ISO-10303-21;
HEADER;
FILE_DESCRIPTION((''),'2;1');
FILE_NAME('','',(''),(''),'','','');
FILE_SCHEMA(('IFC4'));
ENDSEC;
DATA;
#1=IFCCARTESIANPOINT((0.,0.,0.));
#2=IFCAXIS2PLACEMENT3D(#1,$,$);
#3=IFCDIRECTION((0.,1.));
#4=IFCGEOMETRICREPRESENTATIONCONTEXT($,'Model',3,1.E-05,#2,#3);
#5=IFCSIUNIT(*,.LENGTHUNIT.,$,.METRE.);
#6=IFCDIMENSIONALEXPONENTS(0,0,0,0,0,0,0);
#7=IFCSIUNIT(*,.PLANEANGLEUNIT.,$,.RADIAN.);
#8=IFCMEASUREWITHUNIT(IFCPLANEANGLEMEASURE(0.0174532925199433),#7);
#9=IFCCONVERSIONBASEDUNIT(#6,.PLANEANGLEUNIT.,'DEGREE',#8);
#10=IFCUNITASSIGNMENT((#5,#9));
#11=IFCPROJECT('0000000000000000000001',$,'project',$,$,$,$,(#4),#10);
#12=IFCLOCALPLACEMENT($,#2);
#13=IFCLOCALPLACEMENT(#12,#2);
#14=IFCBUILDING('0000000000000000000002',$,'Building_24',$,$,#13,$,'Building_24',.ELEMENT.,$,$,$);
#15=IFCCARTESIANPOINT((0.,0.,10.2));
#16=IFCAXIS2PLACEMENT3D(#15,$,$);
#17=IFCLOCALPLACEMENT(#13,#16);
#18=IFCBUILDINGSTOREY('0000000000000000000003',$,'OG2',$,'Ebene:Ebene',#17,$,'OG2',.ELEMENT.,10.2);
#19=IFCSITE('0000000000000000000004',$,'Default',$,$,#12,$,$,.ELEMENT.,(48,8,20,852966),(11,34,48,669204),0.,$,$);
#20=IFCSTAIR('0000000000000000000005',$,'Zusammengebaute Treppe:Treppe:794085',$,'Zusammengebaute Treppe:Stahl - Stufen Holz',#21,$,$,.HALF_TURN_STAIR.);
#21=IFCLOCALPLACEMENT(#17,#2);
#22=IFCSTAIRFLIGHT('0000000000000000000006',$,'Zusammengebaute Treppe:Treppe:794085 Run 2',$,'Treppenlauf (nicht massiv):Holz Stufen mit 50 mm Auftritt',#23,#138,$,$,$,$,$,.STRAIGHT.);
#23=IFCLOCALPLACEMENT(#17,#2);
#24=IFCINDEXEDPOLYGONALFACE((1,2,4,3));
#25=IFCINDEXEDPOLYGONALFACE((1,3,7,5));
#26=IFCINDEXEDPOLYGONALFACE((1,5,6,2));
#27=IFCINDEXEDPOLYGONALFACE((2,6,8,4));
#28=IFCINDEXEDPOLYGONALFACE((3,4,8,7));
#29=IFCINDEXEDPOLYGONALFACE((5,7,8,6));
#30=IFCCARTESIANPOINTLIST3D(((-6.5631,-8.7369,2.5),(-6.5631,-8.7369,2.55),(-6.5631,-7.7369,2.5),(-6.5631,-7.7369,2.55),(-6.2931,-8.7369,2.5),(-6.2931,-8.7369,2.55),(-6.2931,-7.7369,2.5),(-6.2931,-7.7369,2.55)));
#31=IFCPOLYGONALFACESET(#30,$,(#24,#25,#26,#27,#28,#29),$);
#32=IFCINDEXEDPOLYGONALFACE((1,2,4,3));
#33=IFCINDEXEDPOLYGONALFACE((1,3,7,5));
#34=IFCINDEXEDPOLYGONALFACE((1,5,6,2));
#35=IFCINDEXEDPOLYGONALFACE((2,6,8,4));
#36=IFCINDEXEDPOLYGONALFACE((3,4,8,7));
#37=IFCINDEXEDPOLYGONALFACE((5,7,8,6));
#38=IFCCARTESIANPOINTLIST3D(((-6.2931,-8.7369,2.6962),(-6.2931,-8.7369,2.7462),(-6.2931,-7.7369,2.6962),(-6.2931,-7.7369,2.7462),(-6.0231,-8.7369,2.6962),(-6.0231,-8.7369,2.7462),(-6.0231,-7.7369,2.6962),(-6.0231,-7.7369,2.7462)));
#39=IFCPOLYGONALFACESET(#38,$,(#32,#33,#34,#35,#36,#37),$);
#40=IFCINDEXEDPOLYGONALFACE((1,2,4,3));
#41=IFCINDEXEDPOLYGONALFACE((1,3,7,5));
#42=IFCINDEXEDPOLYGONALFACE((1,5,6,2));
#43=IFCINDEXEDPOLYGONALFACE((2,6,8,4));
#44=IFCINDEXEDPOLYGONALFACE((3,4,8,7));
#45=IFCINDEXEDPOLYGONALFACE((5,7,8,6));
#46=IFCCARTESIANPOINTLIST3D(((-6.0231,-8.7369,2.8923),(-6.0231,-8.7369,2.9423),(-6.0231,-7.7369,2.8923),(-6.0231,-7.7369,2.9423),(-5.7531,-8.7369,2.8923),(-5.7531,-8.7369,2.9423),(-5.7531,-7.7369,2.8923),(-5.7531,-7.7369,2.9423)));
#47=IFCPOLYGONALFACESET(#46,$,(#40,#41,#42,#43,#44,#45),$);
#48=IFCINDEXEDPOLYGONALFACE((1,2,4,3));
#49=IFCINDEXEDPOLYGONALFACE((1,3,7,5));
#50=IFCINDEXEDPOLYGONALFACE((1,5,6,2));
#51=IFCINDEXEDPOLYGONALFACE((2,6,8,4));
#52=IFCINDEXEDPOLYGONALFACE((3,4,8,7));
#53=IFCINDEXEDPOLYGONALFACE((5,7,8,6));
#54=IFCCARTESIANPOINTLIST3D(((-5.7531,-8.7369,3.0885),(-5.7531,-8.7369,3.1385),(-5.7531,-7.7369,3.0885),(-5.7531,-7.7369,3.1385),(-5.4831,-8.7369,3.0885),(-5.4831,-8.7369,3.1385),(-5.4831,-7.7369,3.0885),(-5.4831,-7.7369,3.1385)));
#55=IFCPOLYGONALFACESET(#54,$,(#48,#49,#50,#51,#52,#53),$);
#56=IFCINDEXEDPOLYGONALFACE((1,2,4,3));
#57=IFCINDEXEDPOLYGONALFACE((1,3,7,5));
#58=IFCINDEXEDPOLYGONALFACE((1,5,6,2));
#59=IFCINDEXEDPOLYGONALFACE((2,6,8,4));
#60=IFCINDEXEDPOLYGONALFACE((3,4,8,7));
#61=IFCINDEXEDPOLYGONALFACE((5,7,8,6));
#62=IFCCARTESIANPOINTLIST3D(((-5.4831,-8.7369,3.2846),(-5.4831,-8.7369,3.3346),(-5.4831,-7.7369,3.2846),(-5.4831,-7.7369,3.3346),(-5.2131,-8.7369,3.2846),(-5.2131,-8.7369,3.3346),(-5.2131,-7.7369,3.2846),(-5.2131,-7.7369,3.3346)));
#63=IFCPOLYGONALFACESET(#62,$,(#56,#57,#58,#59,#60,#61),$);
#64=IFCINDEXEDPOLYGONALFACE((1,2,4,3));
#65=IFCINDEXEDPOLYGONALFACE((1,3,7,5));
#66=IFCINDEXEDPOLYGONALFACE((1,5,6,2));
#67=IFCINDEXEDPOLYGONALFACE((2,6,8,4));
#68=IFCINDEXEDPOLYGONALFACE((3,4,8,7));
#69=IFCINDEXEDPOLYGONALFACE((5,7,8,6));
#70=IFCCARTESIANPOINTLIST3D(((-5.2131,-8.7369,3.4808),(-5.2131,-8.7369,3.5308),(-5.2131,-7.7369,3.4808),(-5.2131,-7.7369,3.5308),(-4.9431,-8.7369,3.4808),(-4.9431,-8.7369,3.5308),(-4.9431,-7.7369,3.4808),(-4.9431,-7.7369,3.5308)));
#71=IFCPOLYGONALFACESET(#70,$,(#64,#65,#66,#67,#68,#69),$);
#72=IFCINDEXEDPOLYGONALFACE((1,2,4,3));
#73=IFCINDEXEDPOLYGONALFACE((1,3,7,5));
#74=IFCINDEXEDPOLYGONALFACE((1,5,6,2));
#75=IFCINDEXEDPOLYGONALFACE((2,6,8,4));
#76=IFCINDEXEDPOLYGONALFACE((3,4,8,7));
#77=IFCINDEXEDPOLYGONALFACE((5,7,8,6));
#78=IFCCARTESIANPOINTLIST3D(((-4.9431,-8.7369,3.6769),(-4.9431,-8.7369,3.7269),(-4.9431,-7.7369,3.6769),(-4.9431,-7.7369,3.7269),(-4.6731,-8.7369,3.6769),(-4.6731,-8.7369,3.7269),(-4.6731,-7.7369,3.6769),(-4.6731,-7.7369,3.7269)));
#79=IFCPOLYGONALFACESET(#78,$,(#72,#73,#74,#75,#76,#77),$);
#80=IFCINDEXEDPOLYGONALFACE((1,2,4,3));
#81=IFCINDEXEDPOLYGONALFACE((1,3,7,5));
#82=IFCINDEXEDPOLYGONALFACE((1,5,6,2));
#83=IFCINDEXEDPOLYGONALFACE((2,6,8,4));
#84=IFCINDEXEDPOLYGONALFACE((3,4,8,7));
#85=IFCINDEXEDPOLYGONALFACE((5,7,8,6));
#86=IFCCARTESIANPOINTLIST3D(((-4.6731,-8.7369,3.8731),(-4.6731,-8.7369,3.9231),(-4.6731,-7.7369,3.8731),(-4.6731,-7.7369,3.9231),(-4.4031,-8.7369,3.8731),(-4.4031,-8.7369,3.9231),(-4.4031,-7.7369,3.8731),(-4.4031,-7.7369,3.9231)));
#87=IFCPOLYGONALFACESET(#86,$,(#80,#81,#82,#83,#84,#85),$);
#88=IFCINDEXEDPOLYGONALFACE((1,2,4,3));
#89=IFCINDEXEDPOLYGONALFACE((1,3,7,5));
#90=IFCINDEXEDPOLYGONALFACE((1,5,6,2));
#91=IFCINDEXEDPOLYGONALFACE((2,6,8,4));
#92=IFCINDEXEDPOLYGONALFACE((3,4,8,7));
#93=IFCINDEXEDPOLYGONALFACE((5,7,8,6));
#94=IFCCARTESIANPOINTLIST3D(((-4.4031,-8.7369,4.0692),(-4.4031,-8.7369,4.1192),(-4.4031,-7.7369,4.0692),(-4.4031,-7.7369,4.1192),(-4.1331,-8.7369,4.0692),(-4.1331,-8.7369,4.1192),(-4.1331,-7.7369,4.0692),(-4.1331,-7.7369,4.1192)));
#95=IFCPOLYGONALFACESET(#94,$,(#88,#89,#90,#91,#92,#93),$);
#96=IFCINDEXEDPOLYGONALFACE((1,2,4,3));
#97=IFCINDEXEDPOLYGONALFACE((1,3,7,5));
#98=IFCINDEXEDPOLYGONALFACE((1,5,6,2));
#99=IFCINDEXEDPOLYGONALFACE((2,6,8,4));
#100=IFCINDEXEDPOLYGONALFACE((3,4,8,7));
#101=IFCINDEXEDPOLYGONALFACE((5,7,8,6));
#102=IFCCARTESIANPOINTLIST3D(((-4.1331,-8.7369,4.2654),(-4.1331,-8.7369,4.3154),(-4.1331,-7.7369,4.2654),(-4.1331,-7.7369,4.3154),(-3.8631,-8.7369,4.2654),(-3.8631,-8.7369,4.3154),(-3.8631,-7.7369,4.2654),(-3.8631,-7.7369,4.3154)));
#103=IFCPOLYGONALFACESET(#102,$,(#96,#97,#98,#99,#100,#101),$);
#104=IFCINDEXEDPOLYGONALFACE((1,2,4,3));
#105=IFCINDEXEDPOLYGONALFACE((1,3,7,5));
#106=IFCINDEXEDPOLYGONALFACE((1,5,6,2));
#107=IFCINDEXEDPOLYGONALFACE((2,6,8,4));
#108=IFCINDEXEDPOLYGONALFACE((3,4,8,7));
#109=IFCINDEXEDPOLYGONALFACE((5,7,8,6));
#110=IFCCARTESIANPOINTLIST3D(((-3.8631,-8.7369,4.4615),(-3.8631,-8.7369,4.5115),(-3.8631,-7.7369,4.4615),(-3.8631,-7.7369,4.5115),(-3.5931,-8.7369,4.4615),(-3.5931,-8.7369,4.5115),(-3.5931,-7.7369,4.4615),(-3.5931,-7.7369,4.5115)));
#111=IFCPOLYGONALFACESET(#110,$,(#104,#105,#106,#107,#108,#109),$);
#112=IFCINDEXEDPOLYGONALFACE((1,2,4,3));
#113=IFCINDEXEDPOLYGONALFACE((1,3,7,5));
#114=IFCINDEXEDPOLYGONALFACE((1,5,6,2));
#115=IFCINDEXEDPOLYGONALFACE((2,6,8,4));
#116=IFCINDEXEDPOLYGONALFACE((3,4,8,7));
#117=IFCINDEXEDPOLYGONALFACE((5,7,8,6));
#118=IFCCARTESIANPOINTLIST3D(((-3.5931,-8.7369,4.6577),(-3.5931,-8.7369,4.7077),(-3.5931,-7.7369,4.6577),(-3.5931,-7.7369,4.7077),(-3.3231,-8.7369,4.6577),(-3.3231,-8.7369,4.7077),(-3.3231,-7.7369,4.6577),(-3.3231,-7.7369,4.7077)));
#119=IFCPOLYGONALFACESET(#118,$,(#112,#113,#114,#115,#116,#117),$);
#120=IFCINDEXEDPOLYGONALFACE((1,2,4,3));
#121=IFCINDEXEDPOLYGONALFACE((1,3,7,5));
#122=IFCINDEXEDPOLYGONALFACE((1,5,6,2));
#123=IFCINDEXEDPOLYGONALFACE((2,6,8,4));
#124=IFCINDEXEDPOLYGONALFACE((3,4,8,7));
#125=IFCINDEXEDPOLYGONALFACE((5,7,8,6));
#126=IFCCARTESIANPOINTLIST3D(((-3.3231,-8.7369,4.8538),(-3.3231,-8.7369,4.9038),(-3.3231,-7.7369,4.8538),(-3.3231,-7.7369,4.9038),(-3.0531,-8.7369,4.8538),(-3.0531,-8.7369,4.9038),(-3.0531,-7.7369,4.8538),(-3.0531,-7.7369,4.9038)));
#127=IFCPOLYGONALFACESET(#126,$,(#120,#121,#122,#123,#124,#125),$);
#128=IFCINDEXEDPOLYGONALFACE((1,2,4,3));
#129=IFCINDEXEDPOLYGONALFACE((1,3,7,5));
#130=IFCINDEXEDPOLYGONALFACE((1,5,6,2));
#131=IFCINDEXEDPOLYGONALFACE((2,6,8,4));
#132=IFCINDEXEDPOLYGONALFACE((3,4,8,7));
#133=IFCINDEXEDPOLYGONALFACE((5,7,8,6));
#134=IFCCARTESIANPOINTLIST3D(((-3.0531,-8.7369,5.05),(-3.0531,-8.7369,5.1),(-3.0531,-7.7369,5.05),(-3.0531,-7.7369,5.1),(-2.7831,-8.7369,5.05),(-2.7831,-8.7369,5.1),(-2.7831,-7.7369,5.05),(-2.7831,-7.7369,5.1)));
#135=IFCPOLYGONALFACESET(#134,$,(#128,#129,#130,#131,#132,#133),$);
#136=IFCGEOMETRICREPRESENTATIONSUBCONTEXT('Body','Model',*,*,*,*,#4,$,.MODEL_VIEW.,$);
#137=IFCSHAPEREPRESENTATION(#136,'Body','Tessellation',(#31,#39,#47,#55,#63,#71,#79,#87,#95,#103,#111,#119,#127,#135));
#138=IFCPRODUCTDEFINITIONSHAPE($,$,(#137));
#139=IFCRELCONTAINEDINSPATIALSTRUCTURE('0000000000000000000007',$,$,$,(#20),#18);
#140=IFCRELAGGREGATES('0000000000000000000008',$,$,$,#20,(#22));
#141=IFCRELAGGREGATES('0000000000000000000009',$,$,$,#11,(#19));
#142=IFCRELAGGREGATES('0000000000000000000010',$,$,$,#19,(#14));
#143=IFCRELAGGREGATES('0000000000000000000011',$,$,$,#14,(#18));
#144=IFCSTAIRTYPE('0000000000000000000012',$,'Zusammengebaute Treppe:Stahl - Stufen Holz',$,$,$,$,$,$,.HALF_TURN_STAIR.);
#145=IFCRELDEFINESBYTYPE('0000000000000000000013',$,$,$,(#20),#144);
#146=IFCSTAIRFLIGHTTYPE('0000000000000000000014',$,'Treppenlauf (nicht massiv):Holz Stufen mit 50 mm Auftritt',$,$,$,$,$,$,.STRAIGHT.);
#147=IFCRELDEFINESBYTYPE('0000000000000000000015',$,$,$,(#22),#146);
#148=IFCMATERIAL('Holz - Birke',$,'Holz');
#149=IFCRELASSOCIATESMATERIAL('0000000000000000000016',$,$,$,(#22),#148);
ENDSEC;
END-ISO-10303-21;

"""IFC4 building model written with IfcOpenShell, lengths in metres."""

from ifc_helpers import new_model, entity, si_unit, converted_unit, direction, frame, origin, place, context, subcontext, project, spatial, indexed_curve, outline, extrude, material, type_object, element, aggregate, save


model = new_model("IFC4")

# Units and contexts
model_context = context("Model", 3, precision=1e-05, world=origin(), true_north=direction((0.0, 1.0)))
body_context = subcontext(model_context, "Body", "Model", "MODEL_VIEW")
ifc_project = project(units=[si_unit("LENGTHUNIT", "METRE"), converted_unit("PLANEANGLEUNIT", "DEGREE", entity("IfcPlaneAngleMeasure", 0.0174532925199433), si_unit("PLANEANGLEUNIT", "RADIAN"), dimensions=[0, 0, 0, 0, 0, 0, 0])], contexts=[model_context])

# Site, building, storey
site_placement = place(None, origin())
site = spatial("IfcSite", under=ifc_project, at=site_placement, Name="Default", CompositionType="ELEMENT", RefLatitude=(48, 8, 20, 852966), RefLongitude=(11, 34, 48, 669204), RefElevation=0.0)
building_placement = place(site_placement, origin())
building = spatial("IfcBuilding", under=site, at=building_placement, Name="Building_24", LongName="Building_24", CompositionType="ELEMENT")
storey_placement = place(building_placement, frame((0.0, 0.0, 10.2)))
storey = spatial("IfcBuildingStorey", under=building, at=storey_placement, Name="OG2", ObjectType="Ebene:Ebene", LongName="OG2", CompositionType="ELEMENT", Elevation=10.2)

# Stair
stair_type_1 = type_object("IfcStairType", Name="Zusammengebaute Treppe:Stahl - Stufen Holz", PredefinedType="HALF_TURN_STAIR")
stair_1_placement = place(storey_placement, origin())
stair_1 = element("IfcStair", 1, at=stair_1_placement, inside=storey, type_object=stair_type_1, Name="Zusammengebaute Treppe:Treppe:794085", ObjectType="Zusammengebaute Treppe:Stahl - Stufen Holz", PredefinedType="HALF_TURN_STAIR")
ifc_material_1 = material(Name="Holz - Birke", Category="Holz")

# Stair flight
stair_flight_type_1 = type_object("IfcStairFlightType", Name="Treppenlauf (nicht massiv):Holz Stufen mit 50 mm Auftritt", PredefinedType="STRAIGHT")
stair_flight_1_placement = place(stair_1_placement, origin())
stair_flight_1 = element("IfcStairFlight", 2, at=stair_flight_1_placement, type_object=stair_flight_type_1, material=ifc_material_1, Name="Zusammengebaute Treppe:Treppe:794085 Run 2", ObjectType="Treppenlauf (nicht massiv):Holz Stufen mit 50 mm Auftritt", PredefinedType="STRAIGHT", context=body_context, shape_type="SweptSolid", body=[
    extrude(outline(indexed_curve([(-0.135, -0.5), (0.135, -0.5), (0.135, 0.5), (-0.135, 0.5), (-0.135, -0.5)], self_intersect=False)), frame((-6.4281, -8.2369, 2.5), z_axis=(0.0, 0.0, 1.0), x_axis=(-1.0, 0.0, 0.0)), (0.0, 0.0, 1.0), 0.05),
    extrude(outline(indexed_curve([(-0.135, -0.5), (0.135, -0.5), (0.135, 0.5), (-0.135, 0.5), (-0.135, -0.5)], self_intersect=False)), frame((-6.1581, -8.2369, 2.6962), z_axis=(0.0, 0.0, 1.0), x_axis=(-1.0, 0.0, 0.0)), (0.0, 0.0, 1.0), 0.05),
    extrude(outline(indexed_curve([(-0.135, -0.5), (0.135, -0.5), (0.135, 0.5), (-0.135, 0.5), (-0.135, -0.5)], self_intersect=False)), frame((-5.8881, -8.2369, 2.8923), z_axis=(0.0, 0.0, 1.0), x_axis=(-1.0, 0.0, 0.0)), (0.0, 0.0, 1.0), 0.05),
    extrude(outline(indexed_curve([(-0.135, -0.5), (0.135, -0.5), (0.135, 0.5), (-0.135, 0.5), (-0.135, -0.5)], self_intersect=False)), frame((-5.6181, -8.2369, 3.0885), z_axis=(0.0, 0.0, 1.0), x_axis=(-1.0, 0.0, 0.0)), (0.0, 0.0, 1.0), 0.05),
    extrude(outline(indexed_curve([(-0.135, -0.5), (0.135, -0.5), (0.135, 0.5), (-0.135, 0.5), (-0.135, -0.5)], self_intersect=False)), frame((-5.3481, -8.2369, 3.2846), z_axis=(0.0, 0.0, 1.0), x_axis=(-1.0, 0.0, 0.0)), (0.0, 0.0, 1.0), 0.05),
    extrude(outline(indexed_curve([(-0.135, -0.5), (0.135, -0.5), (0.135, 0.5), (-0.135, 0.5), (-0.135, -0.5)], self_intersect=False)), frame((-5.0781, -8.2369, 3.4808), z_axis=(0.0, 0.0, 1.0), x_axis=(-1.0, 0.0, 0.0)), (0.0, 0.0, 1.0), 0.05),
    extrude(outline(indexed_curve([(-0.135, -0.5), (0.135, -0.5), (0.135, 0.5), (-0.135, 0.5), (-0.135, -0.5)], self_intersect=False)), frame((-4.8081, -8.2369, 3.6769), z_axis=(0.0, 0.0, 1.0), x_axis=(-1.0, 0.0, 0.0)), (0.0, 0.0, 1.0), 0.05),
    extrude(outline(indexed_curve([(-0.135, -0.5), (0.135, -0.5), (0.135, 0.5), (-0.135, 0.5), (-0.135, -0.5)], self_intersect=False)), frame((-4.5381, -8.2369, 3.8731), z_axis=(0.0, 0.0, 1.0), x_axis=(-1.0, 0.0, 0.0)), (0.0, 0.0, 1.0), 0.05),
    extrude(outline(indexed_curve([(-0.135, -0.5), (0.135, -0.5), (0.135, 0.5), (-0.135, 0.5), (-0.135, -0.5)], self_intersect=False)), frame((-4.2681, -8.2369, 4.0692), z_axis=(0.0, 0.0, 1.0), x_axis=(-1.0, 0.0, 0.0)), (0.0, 0.0, 1.0), 0.05),
    extrude(outline(indexed_curve([(-0.135, -0.5), (0.135, -0.5), (0.135, 0.5), (-0.135, 0.5), (-0.135, -0.5)], self_intersect=False)), frame((-3.9981, -8.2369, 4.2654), z_axis=(0.0, 0.0, 1.0), x_axis=(-1.0, 0.0, 0.0)), (0.0, 0.0, 1.0), 0.05),
    extrude(outline(indexed_curve([(-0.135, -0.5), (0.135, -0.5), (0.135, 0.5), (-0.135, 0.5), (-0.135, -0.5)], self_intersect=False)), frame((-3.7281, -8.2369, 4.4615), z_axis=(0.0, 0.0, 1.0), x_axis=(-1.0, 0.0, 0.0)), (0.0, 0.0, 1.0), 0.05),
    extrude(outline(indexed_curve([(-0.135, -0.5), (0.135, -0.5), (0.135, 0.5), (-0.135, 0.5), (-0.135, -0.5)], self_intersect=False)), frame((-3.4581, -8.2369, 4.6577), z_axis=(0.0, 0.0, 1.0), x_axis=(-1.0, 0.0, 0.0)), (0.0, 0.0, 1.0), 0.05),
    extrude(outline(indexed_curve([(-0.135, -0.5), (0.135, -0.5), (0.135, 0.5), (-0.135, 0.5), (-0.135, -0.5)], self_intersect=False)), frame((-3.1881, -8.2369, 4.8538), z_axis=(0.0, 0.0, 1.0), x_axis=(-1.0, 0.0, 0.0)), (0.0, 0.0, 1.0), 0.05),
    extrude(outline(indexed_curve([(-0.135, -0.5), (0.135, -0.5), (0.135, 0.5), (-0.135, 0.5), (-0.135, -0.5)], self_intersect=False)), frame((-2.9181, -8.2369, 5.05), z_axis=(0.0, 0.0, 1.0), x_axis=(-1.0, 0.0, 0.0)), (0.0, 0.0, 1.0), 0.05),
])
aggregate(stair_1, [stair_flight_1])

save(model, "model.ifc")
